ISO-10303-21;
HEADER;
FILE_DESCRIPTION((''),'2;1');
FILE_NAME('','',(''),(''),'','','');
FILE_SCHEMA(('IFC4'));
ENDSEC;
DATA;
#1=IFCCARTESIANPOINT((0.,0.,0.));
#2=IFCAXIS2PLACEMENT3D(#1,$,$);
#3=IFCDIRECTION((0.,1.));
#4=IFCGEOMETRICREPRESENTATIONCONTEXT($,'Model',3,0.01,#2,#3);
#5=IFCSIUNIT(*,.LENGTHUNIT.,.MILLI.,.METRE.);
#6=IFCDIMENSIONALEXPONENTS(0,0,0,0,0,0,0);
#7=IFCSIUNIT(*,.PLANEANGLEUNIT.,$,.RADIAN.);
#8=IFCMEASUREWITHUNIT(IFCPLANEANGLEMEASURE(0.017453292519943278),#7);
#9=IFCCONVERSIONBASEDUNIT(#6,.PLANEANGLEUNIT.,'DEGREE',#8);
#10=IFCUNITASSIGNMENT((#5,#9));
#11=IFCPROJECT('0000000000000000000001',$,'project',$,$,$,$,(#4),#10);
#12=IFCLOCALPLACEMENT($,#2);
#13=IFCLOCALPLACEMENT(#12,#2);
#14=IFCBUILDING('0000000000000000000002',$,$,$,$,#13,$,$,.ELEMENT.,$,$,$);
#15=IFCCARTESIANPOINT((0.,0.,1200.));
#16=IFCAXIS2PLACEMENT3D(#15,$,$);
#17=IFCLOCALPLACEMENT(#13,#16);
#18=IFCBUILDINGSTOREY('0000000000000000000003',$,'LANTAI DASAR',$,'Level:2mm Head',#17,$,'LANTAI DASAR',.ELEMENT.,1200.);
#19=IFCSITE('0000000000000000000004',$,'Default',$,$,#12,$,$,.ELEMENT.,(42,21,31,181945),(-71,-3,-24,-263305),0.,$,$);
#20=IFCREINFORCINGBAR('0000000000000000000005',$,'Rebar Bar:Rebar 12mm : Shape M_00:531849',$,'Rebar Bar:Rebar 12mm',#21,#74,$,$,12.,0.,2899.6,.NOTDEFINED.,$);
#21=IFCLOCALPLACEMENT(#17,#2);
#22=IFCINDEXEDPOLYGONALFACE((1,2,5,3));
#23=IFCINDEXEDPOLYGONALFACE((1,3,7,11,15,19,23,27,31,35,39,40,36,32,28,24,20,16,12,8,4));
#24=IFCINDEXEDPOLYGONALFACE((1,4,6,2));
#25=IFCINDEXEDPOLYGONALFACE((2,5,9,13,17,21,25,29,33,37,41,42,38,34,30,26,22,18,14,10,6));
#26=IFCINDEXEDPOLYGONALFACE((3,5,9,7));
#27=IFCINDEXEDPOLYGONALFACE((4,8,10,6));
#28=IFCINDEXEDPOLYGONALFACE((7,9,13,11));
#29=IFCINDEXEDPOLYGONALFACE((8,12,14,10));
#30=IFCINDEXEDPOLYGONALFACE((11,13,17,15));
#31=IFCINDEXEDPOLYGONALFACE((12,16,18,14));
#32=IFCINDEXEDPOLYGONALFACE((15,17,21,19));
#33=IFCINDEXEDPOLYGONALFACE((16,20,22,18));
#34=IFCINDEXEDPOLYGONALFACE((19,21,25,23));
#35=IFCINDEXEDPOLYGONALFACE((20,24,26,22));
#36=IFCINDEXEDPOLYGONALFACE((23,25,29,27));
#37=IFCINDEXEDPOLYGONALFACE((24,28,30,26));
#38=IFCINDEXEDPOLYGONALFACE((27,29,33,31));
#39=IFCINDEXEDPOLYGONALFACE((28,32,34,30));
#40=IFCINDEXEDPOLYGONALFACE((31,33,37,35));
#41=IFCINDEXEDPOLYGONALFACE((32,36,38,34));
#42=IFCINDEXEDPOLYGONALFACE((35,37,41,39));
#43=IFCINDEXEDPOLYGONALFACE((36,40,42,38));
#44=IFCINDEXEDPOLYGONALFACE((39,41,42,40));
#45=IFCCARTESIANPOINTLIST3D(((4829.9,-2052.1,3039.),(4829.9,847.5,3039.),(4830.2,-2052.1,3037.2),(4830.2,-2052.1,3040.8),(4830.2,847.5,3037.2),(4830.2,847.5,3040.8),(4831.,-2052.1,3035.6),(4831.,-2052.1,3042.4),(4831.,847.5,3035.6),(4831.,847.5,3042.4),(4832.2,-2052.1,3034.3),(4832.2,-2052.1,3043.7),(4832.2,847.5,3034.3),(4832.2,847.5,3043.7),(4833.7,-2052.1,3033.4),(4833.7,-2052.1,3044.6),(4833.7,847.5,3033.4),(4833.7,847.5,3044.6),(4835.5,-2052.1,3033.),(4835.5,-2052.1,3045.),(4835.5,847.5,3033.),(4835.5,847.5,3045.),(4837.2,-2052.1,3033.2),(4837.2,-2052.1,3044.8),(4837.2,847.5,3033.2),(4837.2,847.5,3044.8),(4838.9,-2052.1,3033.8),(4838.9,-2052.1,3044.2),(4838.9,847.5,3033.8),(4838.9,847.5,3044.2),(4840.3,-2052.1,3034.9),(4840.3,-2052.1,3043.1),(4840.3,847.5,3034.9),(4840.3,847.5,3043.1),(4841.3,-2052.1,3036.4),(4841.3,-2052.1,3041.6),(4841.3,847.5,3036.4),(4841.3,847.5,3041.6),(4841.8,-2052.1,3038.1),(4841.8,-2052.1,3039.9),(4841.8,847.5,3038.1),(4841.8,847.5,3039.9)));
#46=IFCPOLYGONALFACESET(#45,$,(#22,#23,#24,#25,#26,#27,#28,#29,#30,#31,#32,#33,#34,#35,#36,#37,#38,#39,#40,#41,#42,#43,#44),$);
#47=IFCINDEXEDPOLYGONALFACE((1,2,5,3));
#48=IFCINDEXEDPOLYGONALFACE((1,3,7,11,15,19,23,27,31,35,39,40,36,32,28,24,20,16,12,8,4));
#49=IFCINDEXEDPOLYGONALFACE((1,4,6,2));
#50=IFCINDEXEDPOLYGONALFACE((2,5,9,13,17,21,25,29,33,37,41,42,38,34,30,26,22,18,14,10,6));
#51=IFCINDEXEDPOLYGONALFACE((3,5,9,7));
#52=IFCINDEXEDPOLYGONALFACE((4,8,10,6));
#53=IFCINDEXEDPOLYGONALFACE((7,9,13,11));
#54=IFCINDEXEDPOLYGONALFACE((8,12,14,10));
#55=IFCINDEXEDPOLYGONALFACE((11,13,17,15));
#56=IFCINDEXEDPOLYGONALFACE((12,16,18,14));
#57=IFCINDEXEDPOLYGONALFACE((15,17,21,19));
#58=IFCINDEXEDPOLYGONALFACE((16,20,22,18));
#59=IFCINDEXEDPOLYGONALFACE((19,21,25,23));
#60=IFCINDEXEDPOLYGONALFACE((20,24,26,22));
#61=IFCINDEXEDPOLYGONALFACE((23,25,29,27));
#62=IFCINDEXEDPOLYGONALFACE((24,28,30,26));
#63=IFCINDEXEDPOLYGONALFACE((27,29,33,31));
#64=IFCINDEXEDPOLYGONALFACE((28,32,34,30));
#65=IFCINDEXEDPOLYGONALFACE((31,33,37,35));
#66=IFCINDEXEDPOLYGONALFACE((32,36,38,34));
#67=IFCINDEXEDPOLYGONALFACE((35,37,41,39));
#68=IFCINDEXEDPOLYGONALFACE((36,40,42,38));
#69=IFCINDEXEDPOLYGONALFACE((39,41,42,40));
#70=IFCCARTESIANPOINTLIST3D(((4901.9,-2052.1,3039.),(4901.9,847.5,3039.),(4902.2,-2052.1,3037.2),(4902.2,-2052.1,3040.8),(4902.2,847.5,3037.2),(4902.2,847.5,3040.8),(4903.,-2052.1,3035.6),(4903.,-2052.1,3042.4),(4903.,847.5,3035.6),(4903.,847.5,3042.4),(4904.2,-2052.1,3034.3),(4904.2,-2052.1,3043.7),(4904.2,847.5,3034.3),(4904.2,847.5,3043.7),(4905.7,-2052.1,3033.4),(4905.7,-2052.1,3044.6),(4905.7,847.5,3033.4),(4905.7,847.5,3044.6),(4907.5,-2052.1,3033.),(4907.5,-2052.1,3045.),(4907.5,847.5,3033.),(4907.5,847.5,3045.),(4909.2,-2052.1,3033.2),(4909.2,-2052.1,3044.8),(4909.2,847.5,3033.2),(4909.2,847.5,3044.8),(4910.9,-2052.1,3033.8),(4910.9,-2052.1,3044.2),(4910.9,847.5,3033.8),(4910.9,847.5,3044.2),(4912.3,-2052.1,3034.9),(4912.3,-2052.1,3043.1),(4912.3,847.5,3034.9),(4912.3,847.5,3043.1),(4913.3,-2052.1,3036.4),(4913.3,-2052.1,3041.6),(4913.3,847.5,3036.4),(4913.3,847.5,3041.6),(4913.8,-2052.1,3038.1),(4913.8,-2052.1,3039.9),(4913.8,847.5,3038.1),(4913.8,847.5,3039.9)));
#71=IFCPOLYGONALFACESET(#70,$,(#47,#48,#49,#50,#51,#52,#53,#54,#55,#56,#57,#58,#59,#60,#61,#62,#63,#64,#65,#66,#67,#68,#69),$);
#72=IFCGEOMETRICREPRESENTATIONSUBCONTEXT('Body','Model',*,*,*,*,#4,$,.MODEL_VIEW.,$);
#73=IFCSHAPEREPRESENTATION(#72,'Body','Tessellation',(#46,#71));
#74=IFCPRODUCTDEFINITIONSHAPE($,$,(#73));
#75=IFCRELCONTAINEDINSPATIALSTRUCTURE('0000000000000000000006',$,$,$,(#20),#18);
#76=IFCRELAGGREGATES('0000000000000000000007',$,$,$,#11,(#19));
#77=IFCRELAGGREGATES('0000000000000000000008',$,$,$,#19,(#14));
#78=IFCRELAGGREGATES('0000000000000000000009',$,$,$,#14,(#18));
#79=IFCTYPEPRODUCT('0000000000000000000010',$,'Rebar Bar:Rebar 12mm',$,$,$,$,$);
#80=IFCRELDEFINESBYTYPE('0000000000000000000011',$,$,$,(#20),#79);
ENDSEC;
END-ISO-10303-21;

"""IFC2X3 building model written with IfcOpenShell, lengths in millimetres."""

from ifc_helpers import new_model, entity, si_unit, converted_unit, direction, frame, origin, place, context, subcontext, project, spatial, type_object, element, save


model = new_model("IFC2X3")

# Units and contexts
model_context = context("Model", 3, precision=0.01, world=origin(), true_north=direction((0.0, 1.0)))
body_context = subcontext(model_context, "Body", "Model", "MODEL_VIEW")
ifc_project = project(units=[si_unit("LENGTHUNIT", "METRE", prefix="MILLI"), converted_unit("PLANEANGLEUNIT", "DEGREE", entity("IfcPlaneAngleMeasure", 0.017453292519943278), si_unit("PLANEANGLEUNIT", "RADIAN"), dimensions=[0, 0, 0, 0, 0, 0, 0])], contexts=[model_context])

# Site, building, storey
site_placement = place(None, origin())
site = spatial("IfcSite", under=ifc_project, at=site_placement, Name="Default", CompositionType="ELEMENT", RefLatitude=(42, 21, 31, 181945), RefLongitude=(-71, -3, -24, -263305), RefElevation=0.0)
building_placement = place(site_placement, origin())
building = spatial("IfcBuilding", under=site, at=building_placement, CompositionType="ELEMENT")
storey_placement = place(building_placement, frame((0.0, 0.0, 1200.0)))
storey = spatial("IfcBuildingStorey", under=building, at=storey_placement, Name="LANTAI DASAR", ObjectType="Level:2mm Head", LongName="LANTAI DASAR", CompositionType="ELEMENT", Elevation=1200.0)

# Reinforcing bar
type_product_1 = type_object("IfcTypeProduct", Name="Rebar Bar:Rebar 12mm")
reinforcing_bar_1_placement = place(storey_placement, origin())
element("IfcReinforcingBar", 1, at=reinforcing_bar_1_placement, inside=storey, type_object=type_product_1, Name="Rebar Bar:Rebar 12mm : Shape M_00:531849", ObjectType="Rebar Bar:Rebar 12mm", BarLength=2899.6, BarRole="NOTDEFINED", CrossSectionArea=0.0, NominalDiameter=12.0, context=body_context, shape_type="AdvancedSweptSolid", body=[
    entity("IfcSweptDiskSolid", entity("IfcCompositeCurve", [entity("IfcCompositeCurveSegment", "CONTINUOUS", True, entity("IfcPolyline", [entity("IfcCartesianPoint", [4835.9, 847.5, 3039.0]), entity("IfcCartesianPoint", [4835.9, -2052.1, 3039.0])]))], False), 6.0, None, 0.0, 1.0),
    entity("IfcSweptDiskSolid", entity("IfcCompositeCurve", [entity("IfcCompositeCurveSegment", "CONTINUOUS", True, entity("IfcPolyline", [entity("IfcCartesianPoint", [4907.9, 847.5, 3039.0]), entity("IfcCartesianPoint", [4907.9, -2052.1, 3039.0])]))], False), 6.0, None, 0.0, 1.0),
])

save(model, "model.ifc")
